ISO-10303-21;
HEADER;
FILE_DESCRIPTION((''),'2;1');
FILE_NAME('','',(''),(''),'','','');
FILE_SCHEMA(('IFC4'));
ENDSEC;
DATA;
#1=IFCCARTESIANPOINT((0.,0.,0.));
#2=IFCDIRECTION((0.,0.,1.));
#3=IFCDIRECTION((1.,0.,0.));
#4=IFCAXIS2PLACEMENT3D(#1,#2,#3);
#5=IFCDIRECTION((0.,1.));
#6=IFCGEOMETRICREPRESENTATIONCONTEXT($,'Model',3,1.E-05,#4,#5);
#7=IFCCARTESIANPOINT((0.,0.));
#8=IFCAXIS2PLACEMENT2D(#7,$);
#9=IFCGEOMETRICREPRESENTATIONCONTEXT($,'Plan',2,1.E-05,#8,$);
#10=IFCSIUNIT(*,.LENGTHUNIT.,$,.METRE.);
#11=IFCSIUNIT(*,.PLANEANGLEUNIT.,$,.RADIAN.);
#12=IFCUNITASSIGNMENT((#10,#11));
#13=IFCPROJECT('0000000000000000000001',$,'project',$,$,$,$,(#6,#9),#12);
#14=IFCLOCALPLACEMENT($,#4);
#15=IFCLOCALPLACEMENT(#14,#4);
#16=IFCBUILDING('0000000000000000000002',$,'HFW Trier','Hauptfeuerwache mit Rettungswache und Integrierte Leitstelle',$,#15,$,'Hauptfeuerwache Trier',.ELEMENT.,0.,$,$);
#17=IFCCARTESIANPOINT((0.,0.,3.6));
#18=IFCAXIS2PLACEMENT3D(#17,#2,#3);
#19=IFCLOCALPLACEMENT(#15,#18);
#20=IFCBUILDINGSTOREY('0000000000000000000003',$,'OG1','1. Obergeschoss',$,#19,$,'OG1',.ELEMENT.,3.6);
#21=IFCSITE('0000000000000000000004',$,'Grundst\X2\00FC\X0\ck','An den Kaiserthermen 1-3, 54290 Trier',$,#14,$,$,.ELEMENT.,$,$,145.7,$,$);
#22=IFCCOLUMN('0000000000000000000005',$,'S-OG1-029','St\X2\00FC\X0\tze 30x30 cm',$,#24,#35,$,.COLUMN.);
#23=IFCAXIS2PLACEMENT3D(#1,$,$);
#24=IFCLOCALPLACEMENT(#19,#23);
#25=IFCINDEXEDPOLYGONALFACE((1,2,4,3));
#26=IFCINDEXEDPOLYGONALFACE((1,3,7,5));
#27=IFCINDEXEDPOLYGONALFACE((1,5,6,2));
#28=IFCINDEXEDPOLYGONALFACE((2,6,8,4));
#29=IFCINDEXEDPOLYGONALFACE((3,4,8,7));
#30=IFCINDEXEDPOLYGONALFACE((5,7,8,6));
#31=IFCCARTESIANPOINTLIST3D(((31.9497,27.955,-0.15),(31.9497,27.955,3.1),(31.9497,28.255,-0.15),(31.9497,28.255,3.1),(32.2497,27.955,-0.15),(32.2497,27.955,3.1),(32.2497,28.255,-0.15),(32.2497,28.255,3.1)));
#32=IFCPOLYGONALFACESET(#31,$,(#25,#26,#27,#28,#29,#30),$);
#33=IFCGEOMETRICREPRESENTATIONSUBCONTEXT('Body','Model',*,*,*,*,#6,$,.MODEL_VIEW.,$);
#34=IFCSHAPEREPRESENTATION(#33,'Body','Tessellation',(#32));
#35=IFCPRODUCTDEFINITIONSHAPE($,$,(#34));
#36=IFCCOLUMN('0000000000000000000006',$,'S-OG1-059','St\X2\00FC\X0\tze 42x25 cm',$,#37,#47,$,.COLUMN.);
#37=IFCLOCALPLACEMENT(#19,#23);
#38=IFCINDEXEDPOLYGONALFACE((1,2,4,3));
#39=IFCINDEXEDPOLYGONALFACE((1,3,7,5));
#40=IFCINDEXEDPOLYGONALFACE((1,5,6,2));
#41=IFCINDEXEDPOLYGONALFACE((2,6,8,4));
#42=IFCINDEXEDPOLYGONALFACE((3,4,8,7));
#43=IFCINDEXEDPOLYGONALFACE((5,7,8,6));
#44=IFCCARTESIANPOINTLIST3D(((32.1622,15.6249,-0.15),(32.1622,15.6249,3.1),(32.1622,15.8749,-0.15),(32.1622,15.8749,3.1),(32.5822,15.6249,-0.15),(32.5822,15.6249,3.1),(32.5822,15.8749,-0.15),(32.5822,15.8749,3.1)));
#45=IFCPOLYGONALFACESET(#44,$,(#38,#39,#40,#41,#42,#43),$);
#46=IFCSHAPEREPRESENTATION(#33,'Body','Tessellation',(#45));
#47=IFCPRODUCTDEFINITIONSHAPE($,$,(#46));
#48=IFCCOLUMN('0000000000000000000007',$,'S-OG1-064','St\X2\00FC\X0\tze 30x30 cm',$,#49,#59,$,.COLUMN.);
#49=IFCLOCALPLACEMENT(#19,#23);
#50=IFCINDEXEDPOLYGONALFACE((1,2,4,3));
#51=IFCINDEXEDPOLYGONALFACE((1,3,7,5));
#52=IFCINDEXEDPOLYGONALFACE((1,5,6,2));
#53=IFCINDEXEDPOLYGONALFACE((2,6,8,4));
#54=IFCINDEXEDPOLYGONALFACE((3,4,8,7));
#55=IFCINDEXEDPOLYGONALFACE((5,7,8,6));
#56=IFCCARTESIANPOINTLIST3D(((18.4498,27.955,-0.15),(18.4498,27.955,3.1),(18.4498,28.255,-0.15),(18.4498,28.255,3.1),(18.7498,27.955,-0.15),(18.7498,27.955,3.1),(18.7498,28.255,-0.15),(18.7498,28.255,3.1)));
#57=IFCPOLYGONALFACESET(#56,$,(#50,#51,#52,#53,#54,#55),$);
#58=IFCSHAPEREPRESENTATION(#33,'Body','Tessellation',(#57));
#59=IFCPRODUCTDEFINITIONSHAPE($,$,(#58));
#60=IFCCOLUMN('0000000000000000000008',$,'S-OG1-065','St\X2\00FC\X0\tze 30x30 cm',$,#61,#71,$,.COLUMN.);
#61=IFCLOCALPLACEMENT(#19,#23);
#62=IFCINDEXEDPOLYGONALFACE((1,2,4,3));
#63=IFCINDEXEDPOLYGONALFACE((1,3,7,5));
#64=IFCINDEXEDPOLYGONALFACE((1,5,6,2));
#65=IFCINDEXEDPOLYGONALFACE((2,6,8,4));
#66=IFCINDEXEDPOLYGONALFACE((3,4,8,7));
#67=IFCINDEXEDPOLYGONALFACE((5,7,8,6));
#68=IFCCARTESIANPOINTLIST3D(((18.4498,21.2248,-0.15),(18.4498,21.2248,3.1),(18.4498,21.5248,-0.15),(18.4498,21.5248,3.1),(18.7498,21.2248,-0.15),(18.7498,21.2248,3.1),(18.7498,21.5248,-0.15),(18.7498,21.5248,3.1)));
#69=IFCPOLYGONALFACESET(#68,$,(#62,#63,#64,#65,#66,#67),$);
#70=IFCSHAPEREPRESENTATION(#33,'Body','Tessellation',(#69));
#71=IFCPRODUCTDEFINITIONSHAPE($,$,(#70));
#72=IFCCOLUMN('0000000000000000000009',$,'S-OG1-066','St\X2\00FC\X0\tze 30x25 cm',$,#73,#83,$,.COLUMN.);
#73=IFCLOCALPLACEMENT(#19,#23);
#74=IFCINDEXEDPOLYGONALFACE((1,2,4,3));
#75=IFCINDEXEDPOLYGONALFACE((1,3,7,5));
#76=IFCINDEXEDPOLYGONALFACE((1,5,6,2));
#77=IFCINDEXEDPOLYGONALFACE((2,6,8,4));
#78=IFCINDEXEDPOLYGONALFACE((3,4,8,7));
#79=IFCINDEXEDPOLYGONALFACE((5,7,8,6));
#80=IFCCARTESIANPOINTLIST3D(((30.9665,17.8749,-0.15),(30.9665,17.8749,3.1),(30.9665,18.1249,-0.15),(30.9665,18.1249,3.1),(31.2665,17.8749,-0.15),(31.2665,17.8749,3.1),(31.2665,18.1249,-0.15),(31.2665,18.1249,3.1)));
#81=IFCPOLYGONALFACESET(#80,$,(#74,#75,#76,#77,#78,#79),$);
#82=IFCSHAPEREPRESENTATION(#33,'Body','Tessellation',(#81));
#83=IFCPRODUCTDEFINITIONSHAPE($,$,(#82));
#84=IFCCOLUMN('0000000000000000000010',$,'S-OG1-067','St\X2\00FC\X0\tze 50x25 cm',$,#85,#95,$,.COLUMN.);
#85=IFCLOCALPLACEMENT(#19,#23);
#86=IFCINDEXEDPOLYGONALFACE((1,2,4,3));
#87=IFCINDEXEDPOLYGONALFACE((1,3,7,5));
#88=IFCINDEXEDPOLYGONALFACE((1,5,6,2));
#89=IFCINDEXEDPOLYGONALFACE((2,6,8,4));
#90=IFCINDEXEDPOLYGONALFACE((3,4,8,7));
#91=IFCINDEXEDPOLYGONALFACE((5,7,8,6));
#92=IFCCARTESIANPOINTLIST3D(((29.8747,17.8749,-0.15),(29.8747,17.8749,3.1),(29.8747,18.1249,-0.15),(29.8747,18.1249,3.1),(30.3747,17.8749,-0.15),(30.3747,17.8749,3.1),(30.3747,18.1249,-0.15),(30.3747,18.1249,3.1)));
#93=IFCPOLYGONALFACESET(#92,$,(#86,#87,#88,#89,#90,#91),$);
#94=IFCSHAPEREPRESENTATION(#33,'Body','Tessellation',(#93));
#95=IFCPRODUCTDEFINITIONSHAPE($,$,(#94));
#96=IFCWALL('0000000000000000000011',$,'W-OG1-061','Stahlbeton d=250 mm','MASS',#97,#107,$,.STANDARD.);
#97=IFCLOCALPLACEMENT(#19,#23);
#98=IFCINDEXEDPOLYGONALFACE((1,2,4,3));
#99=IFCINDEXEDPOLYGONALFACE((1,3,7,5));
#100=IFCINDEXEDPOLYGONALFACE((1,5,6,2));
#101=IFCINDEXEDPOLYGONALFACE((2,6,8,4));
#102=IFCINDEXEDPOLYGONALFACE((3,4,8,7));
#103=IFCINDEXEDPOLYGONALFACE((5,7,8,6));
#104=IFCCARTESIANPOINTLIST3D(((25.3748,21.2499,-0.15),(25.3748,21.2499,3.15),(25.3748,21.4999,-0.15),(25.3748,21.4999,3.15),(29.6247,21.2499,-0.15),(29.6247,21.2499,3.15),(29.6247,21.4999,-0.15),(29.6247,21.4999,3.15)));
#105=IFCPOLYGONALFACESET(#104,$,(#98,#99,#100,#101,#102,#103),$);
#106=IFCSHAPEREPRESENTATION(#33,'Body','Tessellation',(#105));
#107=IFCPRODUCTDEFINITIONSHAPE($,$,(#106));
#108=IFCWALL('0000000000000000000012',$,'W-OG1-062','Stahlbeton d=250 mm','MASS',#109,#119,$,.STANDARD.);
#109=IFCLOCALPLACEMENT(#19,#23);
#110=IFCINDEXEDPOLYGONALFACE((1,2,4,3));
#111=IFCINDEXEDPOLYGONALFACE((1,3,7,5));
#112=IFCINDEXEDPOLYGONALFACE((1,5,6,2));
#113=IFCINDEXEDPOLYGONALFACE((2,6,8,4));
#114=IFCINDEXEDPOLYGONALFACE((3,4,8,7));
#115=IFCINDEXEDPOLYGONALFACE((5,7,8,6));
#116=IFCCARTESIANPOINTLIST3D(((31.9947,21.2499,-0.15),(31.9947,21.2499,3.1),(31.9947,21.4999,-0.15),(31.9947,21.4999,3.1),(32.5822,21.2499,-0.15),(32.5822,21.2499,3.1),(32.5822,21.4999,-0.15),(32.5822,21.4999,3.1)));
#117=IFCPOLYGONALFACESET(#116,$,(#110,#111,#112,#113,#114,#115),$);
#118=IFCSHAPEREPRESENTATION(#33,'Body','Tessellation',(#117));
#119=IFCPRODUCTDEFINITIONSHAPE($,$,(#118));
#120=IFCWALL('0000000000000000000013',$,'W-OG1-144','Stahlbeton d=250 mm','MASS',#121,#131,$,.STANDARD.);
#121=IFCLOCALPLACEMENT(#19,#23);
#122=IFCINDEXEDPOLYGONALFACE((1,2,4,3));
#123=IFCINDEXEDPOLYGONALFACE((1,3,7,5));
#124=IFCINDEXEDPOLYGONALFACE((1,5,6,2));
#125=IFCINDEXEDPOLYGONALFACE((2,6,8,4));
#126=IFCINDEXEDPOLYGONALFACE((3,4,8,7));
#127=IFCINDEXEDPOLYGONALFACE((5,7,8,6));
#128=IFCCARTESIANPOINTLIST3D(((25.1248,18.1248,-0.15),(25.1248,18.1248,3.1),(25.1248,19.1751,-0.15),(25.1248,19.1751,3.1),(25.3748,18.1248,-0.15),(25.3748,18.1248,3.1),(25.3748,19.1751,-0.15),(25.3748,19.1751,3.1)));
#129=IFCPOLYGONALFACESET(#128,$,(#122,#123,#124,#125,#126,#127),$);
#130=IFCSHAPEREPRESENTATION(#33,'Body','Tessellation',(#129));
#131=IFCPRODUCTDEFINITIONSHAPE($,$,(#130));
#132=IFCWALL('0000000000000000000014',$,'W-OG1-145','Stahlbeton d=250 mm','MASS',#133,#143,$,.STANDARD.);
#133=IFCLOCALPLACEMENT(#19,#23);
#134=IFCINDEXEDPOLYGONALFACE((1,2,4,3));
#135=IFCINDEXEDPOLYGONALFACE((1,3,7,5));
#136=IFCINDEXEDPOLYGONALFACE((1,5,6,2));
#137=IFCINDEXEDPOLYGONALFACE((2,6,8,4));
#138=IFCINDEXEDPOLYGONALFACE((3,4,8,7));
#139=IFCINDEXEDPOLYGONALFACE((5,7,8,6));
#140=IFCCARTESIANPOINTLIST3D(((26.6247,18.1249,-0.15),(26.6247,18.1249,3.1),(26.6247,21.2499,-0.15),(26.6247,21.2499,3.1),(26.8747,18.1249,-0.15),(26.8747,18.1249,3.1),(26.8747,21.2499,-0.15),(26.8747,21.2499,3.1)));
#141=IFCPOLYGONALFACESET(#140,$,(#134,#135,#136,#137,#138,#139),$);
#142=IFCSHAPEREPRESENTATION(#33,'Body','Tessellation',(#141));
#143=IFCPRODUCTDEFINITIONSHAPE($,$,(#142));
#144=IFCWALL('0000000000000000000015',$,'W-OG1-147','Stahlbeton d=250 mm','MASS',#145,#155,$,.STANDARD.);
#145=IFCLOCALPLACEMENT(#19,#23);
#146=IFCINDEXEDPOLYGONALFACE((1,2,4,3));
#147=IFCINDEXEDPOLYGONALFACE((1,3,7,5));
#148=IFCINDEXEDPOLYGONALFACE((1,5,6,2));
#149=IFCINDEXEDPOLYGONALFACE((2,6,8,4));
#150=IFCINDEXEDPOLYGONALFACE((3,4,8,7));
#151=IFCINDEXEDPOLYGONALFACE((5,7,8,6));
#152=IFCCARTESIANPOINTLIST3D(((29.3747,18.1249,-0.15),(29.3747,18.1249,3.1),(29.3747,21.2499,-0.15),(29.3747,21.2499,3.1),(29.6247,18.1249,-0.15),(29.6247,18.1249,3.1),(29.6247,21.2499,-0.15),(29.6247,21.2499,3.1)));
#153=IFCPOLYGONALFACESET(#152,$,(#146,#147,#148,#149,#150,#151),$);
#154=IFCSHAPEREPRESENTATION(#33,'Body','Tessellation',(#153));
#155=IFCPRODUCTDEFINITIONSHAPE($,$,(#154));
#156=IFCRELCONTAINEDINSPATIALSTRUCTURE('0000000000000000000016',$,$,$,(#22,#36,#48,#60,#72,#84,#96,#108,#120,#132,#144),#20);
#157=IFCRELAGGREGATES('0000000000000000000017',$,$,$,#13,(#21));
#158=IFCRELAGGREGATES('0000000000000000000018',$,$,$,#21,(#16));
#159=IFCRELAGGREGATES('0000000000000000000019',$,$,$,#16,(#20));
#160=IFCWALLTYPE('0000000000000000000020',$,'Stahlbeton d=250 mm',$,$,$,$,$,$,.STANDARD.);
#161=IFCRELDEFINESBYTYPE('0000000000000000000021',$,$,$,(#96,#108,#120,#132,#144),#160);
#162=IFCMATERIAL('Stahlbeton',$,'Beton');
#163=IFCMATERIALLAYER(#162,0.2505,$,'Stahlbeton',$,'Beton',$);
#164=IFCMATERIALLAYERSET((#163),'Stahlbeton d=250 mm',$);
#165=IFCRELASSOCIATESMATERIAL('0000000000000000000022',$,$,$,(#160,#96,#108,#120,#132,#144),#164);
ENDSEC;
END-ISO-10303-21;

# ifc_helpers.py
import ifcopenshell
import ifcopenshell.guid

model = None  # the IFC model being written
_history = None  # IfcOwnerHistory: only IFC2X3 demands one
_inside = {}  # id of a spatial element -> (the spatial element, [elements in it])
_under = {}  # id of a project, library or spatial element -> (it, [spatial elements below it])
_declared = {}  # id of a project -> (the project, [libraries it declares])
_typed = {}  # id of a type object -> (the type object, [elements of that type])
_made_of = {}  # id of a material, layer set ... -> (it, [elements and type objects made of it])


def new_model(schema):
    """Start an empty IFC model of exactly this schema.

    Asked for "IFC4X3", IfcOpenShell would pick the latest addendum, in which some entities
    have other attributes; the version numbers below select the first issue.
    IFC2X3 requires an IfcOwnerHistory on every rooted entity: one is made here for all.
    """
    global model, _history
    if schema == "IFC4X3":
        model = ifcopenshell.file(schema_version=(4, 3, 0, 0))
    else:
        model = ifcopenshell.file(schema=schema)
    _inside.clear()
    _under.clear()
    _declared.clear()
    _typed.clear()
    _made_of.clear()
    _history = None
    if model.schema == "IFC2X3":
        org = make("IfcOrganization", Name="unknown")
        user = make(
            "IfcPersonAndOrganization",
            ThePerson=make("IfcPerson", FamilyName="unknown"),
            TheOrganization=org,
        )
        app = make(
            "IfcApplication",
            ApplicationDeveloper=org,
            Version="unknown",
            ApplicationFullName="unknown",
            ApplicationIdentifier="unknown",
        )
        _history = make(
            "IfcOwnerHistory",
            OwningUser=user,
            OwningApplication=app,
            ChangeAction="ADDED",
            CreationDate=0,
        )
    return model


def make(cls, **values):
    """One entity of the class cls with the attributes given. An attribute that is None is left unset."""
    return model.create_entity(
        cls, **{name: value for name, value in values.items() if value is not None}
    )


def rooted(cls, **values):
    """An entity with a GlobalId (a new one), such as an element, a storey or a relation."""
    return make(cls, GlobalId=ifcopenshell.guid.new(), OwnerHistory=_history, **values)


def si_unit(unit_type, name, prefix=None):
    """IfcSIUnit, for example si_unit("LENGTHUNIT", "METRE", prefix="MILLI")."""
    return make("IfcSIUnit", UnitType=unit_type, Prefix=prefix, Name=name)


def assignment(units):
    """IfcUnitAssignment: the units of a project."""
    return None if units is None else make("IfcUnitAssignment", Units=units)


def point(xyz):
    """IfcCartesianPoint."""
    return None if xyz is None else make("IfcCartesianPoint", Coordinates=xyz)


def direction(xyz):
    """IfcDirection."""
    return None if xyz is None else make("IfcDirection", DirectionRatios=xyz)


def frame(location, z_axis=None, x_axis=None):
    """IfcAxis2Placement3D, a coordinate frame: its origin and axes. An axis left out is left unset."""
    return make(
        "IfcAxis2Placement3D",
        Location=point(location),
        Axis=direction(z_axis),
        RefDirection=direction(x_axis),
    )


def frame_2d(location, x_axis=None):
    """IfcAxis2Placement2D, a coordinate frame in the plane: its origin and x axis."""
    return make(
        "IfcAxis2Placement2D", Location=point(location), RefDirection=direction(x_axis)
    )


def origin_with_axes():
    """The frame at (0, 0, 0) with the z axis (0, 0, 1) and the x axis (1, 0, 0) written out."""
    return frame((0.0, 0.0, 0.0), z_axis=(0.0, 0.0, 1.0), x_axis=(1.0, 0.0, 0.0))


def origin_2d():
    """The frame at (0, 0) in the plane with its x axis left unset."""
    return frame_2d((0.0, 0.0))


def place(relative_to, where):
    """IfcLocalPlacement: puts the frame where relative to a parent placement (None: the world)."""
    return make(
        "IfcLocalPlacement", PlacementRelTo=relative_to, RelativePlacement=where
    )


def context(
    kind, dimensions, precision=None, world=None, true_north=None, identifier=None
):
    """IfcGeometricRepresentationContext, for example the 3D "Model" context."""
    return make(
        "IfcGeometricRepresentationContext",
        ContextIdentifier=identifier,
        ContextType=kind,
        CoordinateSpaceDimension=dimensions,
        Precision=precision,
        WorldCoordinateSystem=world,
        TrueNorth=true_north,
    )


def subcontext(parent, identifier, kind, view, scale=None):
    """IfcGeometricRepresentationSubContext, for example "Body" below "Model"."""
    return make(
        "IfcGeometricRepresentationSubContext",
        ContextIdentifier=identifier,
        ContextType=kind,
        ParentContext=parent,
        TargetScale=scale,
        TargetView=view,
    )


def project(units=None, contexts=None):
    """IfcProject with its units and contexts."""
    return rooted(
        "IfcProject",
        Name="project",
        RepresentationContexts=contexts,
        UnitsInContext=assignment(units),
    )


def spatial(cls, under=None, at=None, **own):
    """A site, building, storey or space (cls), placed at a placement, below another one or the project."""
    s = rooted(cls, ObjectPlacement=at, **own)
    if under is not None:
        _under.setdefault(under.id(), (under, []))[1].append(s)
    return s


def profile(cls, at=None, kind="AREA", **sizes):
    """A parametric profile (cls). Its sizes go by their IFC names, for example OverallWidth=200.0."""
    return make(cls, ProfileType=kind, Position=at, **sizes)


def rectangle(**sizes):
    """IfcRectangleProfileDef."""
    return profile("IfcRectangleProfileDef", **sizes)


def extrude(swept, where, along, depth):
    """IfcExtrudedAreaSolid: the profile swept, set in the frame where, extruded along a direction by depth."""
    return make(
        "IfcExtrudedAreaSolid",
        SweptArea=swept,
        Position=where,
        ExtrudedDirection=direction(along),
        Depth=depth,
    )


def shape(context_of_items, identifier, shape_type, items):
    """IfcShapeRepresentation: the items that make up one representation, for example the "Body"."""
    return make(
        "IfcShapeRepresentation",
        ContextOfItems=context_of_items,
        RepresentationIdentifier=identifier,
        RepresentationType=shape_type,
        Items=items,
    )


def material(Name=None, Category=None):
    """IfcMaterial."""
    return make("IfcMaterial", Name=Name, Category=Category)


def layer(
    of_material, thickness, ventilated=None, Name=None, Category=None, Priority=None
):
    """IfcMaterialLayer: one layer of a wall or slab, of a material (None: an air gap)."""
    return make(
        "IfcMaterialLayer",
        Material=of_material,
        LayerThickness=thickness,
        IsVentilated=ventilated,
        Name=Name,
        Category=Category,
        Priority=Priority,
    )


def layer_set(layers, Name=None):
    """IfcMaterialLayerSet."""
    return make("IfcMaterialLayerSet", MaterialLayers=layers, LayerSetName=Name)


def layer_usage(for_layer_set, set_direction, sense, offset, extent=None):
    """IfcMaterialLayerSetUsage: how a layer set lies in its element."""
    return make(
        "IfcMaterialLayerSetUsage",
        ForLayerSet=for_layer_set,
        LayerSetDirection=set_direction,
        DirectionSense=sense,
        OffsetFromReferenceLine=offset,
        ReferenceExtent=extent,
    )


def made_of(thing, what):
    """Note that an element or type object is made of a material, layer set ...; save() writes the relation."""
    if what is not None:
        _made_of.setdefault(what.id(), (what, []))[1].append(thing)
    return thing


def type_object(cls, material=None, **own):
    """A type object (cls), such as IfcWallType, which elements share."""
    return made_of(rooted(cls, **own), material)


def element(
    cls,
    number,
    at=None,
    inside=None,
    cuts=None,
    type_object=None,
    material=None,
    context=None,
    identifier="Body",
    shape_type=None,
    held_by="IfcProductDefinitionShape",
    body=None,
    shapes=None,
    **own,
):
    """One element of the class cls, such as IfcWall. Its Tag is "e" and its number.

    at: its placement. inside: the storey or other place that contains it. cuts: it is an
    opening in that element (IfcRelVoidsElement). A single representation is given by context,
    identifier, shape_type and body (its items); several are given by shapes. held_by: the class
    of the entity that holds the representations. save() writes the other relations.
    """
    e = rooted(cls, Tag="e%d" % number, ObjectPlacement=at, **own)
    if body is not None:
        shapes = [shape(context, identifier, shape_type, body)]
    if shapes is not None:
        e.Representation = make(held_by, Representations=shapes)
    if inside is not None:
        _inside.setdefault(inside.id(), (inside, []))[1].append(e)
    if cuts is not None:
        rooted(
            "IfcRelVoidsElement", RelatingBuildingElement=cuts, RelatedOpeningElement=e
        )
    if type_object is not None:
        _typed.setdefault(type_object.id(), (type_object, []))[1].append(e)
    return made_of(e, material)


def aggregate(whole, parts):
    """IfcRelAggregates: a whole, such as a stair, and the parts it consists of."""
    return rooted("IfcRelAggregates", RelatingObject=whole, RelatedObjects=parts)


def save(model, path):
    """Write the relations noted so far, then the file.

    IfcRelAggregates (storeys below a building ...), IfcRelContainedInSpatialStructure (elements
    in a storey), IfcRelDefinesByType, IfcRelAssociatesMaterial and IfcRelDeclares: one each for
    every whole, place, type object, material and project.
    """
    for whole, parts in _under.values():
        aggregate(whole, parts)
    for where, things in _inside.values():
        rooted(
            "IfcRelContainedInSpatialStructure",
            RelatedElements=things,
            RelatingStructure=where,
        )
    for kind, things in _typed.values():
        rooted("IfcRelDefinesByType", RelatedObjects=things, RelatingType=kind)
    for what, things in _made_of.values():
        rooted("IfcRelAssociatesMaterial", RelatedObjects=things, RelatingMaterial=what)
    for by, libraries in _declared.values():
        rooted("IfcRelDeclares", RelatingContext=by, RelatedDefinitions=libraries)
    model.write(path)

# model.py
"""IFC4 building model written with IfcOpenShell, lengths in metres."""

from ifc_helpers import new_model, si_unit, direction, frame, frame_2d, origin_with_axes, origin_2d, place, context, subcontext, project, spatial, rectangle, extrude, material, layer, layer_set, layer_usage, type_object, element, save


model = new_model("IFC4")

# Units and contexts
model_context = context("Model", 3, precision=1e-05, world=origin_with_axes(), true_north=direction((0.0, 1.0)))
plan_context = context("Plan", 2, precision=1e-05, world=origin_2d())
body_context = subcontext(model_context, "Body", "Model", "MODEL_VIEW")
ifc_project = project(units=[si_unit("LENGTHUNIT", "METRE"), si_unit("PLANEANGLEUNIT", "RADIAN")], contexts=[model_context, plan_context])

# Site, building, storey
site_placement = place(None, origin_with_axes())
site = spatial("IfcSite", under=ifc_project, at=site_placement, Name="Grundstück", Description="An den Kaiserthermen 1-3, 54290 Trier", CompositionType="ELEMENT", RefElevation=145.7)
building_placement = place(site_placement, origin_with_axes())
building = spatial("IfcBuilding", under=site, at=building_placement, Name="HFW Trier", Description="Hauptfeuerwache mit Rettungswache und Integrierte Leitstelle", LongName="Hauptfeuerwache Trier", CompositionType="ELEMENT", ElevationOfRefHeight=0.0)
storey_placement = place(building_placement, frame((0.0, 0.0, 3.6), z_axis=(0.0, 0.0, 1.0), x_axis=(1.0, 0.0, 0.0)))
storey = spatial("IfcBuildingStorey", under=building, at=storey_placement, Name="OG1", Description="1. Obergeschoss", LongName="OG1", CompositionType="ELEMENT", Elevation=3.6)

# Columns
column_1_placement = place(storey_placement, frame((31.9497, 28.105, -0.15), z_axis=(0.0, 0.0, 1.0), x_axis=(1.0, 0.0, 0.0)))
element("IfcColumn", 1, at=column_1_placement, inside=storey, Name="S-OG1-029", Description="Stütze 30x30 cm", PredefinedType="COLUMN", context=body_context, shape_type="SweptSolid", body=[
    extrude(rectangle(XDim=0.3, YDim=0.3, at=frame_2d((0.15, 0.0))), origin_with_axes(), (0.0, 0.0, 1.0), 3.25),
])
column_2_placement = place(storey_placement, frame((32.1622, 15.7499, -0.15), z_axis=(0.0, 0.0, 1.0), x_axis=(1.0, 0.0, 0.0)))
element("IfcColumn", 2, at=column_2_placement, inside=storey, Name="S-OG1-059", Description="Stütze 42x25 cm", PredefinedType="COLUMN", context=body_context, shape_type="SweptSolid", body=[
    extrude(rectangle(XDim=0.42, YDim=0.25, at=frame_2d((0.21, 0.0))), origin_with_axes(), (0.0, 0.0, 1.0), 3.25),
])
for number, where, z_axis, x_axis, name in (
    (3, (18.4498, 28.105, -0.15), (0.0, 0.0, 1.0), (1.0, 0.0, 0.0), "S-OG1-064"),
    (4, (18.4498, 21.3748, -0.15), (0.0, 0.0, 1.0), (1.0, 0.0, 0.0), "S-OG1-065"),
):
    element("IfcColumn", number, at=place(storey_placement, frame(where, z_axis=z_axis, x_axis=x_axis)), inside=storey, Name=name, Description="Stütze 30x30 cm", PredefinedType="COLUMN", context=body_context, shape_type="SweptSolid", body=[
        extrude(rectangle(XDim=0.3, YDim=0.3, at=frame_2d((0.15, 0.0))), origin_with_axes(), (0.0, 0.0, 1.0), 3.25),
    ])
column_3_placement = place(storey_placement, frame((30.9665, 17.9999, -0.15), z_axis=(0.0, 0.0, 1.0), x_axis=(1.0, 0.0, 0.0)))
element("IfcColumn", 5, at=column_3_placement, inside=storey, Name="S-OG1-066", Description="Stütze 30x25 cm", PredefinedType="COLUMN", context=body_context, shape_type="SweptSolid", body=[
    extrude(rectangle(XDim=0.3, YDim=0.25, at=frame_2d((0.15, 0.0))), origin_with_axes(), (0.0, 0.0, 1.0), 3.25),
])
column_4_placement = place(storey_placement, frame((29.8747, 17.9999, -0.15), z_axis=(0.0, 0.0, 1.0), x_axis=(1.0, 0.0, 0.0)))
element("IfcColumn", 6, at=column_4_placement, inside=storey, Name="S-OG1-067", Description="Stütze 50x25 cm", PredefinedType="COLUMN", context=body_context, shape_type="SweptSolid", body=[
    extrude(rectangle(XDim=0.5, YDim=0.25, at=frame_2d((0.25, 0.0))), origin_with_axes(), (0.0, 0.0, 1.0), 3.25),
])

# Walls
ifc_material_1 = material(Name="Stahlbeton", Category="Beton")
ifc_layer_1 = layer(ifc_material_1, 0.2505, Name="Stahlbeton", Category="Beton")
ifc_layer_set_1 = layer_set([ifc_layer_1], Name="Stahlbeton d=250 mm")
ifc_layer_usage_1 = layer_usage(ifc_layer_set_1, "AXIS2", "POSITIVE", -0.125)
wall_type_1 = type_object("IfcWallType", Name="Stahlbeton d=250 mm", PredefinedType="STANDARD", material=ifc_layer_set_1)
wall_1_placement = place(storey_placement, frame((25.3748, 21.3749, -0.15), z_axis=(0.0, 0.0, 1.0), x_axis=(1.0, 0.0, 0.0)))
element("IfcWall", 7, at=wall_1_placement, inside=storey, type_object=wall_type_1, material=ifc_layer_usage_1, Name="W-OG1-061", Description="Stahlbeton d=250 mm", ObjectType="MASS", PredefinedType="STANDARD", context=body_context, shape_type="SweptSolid", body=[
    extrude(rectangle(XDim=4.2499, YDim=0.25, at=frame_2d((2.125, 0.0))), origin_with_axes(), (0.0, 0.0, 1.0), 3.3),
])
ifc_layer_usage_2 = layer_usage(ifc_layer_set_1, "AXIS2", "POSITIVE", -0.125)
wall_2_placement = place(storey_placement, frame((31.9947, 21.3749, -0.15), z_axis=(0.0, 0.0, 1.0), x_axis=(1.0, 0.0, 0.0)))
element("IfcWall", 8, at=wall_2_placement, inside=storey, type_object=wall_type_1, material=ifc_layer_usage_2, Name="W-OG1-062", Description="Stahlbeton d=250 mm", ObjectType="MASS", PredefinedType="STANDARD", context=body_context, shape_type="SweptSolid", body=[
    extrude(rectangle(XDim=0.5875, YDim=0.25, at=frame_2d((0.2937, 0.0))), origin_with_axes(), (0.0, 0.0, 1.0), 3.25),
])
ifc_layer_usage_3 = layer_usage(ifc_layer_set_1, "AXIS2", "POSITIVE", -0.125)
wall_3_placement = place(storey_placement, frame((25.2498, 19.1751, -0.15), z_axis=(0.0, 0.0, 1.0), x_axis=(0.0, -1.0, 0.0)))
element("IfcWall", 9, at=wall_3_placement, inside=storey, type_object=wall_type_1, material=ifc_layer_usage_3, Name="W-OG1-144", Description="Stahlbeton d=250 mm", ObjectType="MASS", PredefinedType="STANDARD", context=body_context, shape_type="SweptSolid", body=[
    extrude(rectangle(XDim=1.0503, YDim=0.25, at=frame_2d((0.5252, 0.0))), origin_with_axes(), (0.0, 0.0, 1.0), 3.25),
])
ifc_layer_usage_4 = layer_usage(ifc_layer_set_1, "AXIS2", "POSITIVE", -0.125)
wall_4_placement = place(storey_placement, frame((26.7497, 21.2499, -0.15), z_axis=(0.0, 0.0, 1.0), x_axis=(0.0, -1.0, 0.0)))
element("IfcWall", 10, at=wall_4_placement, inside=storey, type_object=wall_type_1, material=ifc_layer_usage_4, Name="W-OG1-145", Description="Stahlbeton d=250 mm", ObjectType="MASS", PredefinedType="STANDARD", context=body_context, shape_type="SweptSolid", body=[
    extrude(rectangle(XDim=3.125, YDim=0.25, at=frame_2d((1.5625, 0.0))), origin_with_axes(), (0.0, 0.0, 1.0), 3.25),
])
ifc_layer_usage_5 = layer_usage(ifc_layer_set_1, "AXIS2", "POSITIVE", -0.125)
wall_5_placement = place(storey_placement, frame((29.4997, 21.2499, -0.15), z_axis=(0.0, 0.0, 1.0), x_axis=(0.0, -1.0, 0.0)))
element("IfcWall", 11, at=wall_5_placement, inside=storey, type_object=wall_type_1, material=ifc_layer_usage_5, Name="W-OG1-147", Description="Stahlbeton d=250 mm", ObjectType="MASS", PredefinedType="STANDARD", context=body_context, shape_type="SweptSolid", body=[
    extrude(rectangle(XDim=3.125, YDim=0.25, at=frame_2d((1.5625, 0.0))), origin_with_axes(), (0.0, 0.0, 1.0), 3.25),
])

save(model, "model.ifc")
